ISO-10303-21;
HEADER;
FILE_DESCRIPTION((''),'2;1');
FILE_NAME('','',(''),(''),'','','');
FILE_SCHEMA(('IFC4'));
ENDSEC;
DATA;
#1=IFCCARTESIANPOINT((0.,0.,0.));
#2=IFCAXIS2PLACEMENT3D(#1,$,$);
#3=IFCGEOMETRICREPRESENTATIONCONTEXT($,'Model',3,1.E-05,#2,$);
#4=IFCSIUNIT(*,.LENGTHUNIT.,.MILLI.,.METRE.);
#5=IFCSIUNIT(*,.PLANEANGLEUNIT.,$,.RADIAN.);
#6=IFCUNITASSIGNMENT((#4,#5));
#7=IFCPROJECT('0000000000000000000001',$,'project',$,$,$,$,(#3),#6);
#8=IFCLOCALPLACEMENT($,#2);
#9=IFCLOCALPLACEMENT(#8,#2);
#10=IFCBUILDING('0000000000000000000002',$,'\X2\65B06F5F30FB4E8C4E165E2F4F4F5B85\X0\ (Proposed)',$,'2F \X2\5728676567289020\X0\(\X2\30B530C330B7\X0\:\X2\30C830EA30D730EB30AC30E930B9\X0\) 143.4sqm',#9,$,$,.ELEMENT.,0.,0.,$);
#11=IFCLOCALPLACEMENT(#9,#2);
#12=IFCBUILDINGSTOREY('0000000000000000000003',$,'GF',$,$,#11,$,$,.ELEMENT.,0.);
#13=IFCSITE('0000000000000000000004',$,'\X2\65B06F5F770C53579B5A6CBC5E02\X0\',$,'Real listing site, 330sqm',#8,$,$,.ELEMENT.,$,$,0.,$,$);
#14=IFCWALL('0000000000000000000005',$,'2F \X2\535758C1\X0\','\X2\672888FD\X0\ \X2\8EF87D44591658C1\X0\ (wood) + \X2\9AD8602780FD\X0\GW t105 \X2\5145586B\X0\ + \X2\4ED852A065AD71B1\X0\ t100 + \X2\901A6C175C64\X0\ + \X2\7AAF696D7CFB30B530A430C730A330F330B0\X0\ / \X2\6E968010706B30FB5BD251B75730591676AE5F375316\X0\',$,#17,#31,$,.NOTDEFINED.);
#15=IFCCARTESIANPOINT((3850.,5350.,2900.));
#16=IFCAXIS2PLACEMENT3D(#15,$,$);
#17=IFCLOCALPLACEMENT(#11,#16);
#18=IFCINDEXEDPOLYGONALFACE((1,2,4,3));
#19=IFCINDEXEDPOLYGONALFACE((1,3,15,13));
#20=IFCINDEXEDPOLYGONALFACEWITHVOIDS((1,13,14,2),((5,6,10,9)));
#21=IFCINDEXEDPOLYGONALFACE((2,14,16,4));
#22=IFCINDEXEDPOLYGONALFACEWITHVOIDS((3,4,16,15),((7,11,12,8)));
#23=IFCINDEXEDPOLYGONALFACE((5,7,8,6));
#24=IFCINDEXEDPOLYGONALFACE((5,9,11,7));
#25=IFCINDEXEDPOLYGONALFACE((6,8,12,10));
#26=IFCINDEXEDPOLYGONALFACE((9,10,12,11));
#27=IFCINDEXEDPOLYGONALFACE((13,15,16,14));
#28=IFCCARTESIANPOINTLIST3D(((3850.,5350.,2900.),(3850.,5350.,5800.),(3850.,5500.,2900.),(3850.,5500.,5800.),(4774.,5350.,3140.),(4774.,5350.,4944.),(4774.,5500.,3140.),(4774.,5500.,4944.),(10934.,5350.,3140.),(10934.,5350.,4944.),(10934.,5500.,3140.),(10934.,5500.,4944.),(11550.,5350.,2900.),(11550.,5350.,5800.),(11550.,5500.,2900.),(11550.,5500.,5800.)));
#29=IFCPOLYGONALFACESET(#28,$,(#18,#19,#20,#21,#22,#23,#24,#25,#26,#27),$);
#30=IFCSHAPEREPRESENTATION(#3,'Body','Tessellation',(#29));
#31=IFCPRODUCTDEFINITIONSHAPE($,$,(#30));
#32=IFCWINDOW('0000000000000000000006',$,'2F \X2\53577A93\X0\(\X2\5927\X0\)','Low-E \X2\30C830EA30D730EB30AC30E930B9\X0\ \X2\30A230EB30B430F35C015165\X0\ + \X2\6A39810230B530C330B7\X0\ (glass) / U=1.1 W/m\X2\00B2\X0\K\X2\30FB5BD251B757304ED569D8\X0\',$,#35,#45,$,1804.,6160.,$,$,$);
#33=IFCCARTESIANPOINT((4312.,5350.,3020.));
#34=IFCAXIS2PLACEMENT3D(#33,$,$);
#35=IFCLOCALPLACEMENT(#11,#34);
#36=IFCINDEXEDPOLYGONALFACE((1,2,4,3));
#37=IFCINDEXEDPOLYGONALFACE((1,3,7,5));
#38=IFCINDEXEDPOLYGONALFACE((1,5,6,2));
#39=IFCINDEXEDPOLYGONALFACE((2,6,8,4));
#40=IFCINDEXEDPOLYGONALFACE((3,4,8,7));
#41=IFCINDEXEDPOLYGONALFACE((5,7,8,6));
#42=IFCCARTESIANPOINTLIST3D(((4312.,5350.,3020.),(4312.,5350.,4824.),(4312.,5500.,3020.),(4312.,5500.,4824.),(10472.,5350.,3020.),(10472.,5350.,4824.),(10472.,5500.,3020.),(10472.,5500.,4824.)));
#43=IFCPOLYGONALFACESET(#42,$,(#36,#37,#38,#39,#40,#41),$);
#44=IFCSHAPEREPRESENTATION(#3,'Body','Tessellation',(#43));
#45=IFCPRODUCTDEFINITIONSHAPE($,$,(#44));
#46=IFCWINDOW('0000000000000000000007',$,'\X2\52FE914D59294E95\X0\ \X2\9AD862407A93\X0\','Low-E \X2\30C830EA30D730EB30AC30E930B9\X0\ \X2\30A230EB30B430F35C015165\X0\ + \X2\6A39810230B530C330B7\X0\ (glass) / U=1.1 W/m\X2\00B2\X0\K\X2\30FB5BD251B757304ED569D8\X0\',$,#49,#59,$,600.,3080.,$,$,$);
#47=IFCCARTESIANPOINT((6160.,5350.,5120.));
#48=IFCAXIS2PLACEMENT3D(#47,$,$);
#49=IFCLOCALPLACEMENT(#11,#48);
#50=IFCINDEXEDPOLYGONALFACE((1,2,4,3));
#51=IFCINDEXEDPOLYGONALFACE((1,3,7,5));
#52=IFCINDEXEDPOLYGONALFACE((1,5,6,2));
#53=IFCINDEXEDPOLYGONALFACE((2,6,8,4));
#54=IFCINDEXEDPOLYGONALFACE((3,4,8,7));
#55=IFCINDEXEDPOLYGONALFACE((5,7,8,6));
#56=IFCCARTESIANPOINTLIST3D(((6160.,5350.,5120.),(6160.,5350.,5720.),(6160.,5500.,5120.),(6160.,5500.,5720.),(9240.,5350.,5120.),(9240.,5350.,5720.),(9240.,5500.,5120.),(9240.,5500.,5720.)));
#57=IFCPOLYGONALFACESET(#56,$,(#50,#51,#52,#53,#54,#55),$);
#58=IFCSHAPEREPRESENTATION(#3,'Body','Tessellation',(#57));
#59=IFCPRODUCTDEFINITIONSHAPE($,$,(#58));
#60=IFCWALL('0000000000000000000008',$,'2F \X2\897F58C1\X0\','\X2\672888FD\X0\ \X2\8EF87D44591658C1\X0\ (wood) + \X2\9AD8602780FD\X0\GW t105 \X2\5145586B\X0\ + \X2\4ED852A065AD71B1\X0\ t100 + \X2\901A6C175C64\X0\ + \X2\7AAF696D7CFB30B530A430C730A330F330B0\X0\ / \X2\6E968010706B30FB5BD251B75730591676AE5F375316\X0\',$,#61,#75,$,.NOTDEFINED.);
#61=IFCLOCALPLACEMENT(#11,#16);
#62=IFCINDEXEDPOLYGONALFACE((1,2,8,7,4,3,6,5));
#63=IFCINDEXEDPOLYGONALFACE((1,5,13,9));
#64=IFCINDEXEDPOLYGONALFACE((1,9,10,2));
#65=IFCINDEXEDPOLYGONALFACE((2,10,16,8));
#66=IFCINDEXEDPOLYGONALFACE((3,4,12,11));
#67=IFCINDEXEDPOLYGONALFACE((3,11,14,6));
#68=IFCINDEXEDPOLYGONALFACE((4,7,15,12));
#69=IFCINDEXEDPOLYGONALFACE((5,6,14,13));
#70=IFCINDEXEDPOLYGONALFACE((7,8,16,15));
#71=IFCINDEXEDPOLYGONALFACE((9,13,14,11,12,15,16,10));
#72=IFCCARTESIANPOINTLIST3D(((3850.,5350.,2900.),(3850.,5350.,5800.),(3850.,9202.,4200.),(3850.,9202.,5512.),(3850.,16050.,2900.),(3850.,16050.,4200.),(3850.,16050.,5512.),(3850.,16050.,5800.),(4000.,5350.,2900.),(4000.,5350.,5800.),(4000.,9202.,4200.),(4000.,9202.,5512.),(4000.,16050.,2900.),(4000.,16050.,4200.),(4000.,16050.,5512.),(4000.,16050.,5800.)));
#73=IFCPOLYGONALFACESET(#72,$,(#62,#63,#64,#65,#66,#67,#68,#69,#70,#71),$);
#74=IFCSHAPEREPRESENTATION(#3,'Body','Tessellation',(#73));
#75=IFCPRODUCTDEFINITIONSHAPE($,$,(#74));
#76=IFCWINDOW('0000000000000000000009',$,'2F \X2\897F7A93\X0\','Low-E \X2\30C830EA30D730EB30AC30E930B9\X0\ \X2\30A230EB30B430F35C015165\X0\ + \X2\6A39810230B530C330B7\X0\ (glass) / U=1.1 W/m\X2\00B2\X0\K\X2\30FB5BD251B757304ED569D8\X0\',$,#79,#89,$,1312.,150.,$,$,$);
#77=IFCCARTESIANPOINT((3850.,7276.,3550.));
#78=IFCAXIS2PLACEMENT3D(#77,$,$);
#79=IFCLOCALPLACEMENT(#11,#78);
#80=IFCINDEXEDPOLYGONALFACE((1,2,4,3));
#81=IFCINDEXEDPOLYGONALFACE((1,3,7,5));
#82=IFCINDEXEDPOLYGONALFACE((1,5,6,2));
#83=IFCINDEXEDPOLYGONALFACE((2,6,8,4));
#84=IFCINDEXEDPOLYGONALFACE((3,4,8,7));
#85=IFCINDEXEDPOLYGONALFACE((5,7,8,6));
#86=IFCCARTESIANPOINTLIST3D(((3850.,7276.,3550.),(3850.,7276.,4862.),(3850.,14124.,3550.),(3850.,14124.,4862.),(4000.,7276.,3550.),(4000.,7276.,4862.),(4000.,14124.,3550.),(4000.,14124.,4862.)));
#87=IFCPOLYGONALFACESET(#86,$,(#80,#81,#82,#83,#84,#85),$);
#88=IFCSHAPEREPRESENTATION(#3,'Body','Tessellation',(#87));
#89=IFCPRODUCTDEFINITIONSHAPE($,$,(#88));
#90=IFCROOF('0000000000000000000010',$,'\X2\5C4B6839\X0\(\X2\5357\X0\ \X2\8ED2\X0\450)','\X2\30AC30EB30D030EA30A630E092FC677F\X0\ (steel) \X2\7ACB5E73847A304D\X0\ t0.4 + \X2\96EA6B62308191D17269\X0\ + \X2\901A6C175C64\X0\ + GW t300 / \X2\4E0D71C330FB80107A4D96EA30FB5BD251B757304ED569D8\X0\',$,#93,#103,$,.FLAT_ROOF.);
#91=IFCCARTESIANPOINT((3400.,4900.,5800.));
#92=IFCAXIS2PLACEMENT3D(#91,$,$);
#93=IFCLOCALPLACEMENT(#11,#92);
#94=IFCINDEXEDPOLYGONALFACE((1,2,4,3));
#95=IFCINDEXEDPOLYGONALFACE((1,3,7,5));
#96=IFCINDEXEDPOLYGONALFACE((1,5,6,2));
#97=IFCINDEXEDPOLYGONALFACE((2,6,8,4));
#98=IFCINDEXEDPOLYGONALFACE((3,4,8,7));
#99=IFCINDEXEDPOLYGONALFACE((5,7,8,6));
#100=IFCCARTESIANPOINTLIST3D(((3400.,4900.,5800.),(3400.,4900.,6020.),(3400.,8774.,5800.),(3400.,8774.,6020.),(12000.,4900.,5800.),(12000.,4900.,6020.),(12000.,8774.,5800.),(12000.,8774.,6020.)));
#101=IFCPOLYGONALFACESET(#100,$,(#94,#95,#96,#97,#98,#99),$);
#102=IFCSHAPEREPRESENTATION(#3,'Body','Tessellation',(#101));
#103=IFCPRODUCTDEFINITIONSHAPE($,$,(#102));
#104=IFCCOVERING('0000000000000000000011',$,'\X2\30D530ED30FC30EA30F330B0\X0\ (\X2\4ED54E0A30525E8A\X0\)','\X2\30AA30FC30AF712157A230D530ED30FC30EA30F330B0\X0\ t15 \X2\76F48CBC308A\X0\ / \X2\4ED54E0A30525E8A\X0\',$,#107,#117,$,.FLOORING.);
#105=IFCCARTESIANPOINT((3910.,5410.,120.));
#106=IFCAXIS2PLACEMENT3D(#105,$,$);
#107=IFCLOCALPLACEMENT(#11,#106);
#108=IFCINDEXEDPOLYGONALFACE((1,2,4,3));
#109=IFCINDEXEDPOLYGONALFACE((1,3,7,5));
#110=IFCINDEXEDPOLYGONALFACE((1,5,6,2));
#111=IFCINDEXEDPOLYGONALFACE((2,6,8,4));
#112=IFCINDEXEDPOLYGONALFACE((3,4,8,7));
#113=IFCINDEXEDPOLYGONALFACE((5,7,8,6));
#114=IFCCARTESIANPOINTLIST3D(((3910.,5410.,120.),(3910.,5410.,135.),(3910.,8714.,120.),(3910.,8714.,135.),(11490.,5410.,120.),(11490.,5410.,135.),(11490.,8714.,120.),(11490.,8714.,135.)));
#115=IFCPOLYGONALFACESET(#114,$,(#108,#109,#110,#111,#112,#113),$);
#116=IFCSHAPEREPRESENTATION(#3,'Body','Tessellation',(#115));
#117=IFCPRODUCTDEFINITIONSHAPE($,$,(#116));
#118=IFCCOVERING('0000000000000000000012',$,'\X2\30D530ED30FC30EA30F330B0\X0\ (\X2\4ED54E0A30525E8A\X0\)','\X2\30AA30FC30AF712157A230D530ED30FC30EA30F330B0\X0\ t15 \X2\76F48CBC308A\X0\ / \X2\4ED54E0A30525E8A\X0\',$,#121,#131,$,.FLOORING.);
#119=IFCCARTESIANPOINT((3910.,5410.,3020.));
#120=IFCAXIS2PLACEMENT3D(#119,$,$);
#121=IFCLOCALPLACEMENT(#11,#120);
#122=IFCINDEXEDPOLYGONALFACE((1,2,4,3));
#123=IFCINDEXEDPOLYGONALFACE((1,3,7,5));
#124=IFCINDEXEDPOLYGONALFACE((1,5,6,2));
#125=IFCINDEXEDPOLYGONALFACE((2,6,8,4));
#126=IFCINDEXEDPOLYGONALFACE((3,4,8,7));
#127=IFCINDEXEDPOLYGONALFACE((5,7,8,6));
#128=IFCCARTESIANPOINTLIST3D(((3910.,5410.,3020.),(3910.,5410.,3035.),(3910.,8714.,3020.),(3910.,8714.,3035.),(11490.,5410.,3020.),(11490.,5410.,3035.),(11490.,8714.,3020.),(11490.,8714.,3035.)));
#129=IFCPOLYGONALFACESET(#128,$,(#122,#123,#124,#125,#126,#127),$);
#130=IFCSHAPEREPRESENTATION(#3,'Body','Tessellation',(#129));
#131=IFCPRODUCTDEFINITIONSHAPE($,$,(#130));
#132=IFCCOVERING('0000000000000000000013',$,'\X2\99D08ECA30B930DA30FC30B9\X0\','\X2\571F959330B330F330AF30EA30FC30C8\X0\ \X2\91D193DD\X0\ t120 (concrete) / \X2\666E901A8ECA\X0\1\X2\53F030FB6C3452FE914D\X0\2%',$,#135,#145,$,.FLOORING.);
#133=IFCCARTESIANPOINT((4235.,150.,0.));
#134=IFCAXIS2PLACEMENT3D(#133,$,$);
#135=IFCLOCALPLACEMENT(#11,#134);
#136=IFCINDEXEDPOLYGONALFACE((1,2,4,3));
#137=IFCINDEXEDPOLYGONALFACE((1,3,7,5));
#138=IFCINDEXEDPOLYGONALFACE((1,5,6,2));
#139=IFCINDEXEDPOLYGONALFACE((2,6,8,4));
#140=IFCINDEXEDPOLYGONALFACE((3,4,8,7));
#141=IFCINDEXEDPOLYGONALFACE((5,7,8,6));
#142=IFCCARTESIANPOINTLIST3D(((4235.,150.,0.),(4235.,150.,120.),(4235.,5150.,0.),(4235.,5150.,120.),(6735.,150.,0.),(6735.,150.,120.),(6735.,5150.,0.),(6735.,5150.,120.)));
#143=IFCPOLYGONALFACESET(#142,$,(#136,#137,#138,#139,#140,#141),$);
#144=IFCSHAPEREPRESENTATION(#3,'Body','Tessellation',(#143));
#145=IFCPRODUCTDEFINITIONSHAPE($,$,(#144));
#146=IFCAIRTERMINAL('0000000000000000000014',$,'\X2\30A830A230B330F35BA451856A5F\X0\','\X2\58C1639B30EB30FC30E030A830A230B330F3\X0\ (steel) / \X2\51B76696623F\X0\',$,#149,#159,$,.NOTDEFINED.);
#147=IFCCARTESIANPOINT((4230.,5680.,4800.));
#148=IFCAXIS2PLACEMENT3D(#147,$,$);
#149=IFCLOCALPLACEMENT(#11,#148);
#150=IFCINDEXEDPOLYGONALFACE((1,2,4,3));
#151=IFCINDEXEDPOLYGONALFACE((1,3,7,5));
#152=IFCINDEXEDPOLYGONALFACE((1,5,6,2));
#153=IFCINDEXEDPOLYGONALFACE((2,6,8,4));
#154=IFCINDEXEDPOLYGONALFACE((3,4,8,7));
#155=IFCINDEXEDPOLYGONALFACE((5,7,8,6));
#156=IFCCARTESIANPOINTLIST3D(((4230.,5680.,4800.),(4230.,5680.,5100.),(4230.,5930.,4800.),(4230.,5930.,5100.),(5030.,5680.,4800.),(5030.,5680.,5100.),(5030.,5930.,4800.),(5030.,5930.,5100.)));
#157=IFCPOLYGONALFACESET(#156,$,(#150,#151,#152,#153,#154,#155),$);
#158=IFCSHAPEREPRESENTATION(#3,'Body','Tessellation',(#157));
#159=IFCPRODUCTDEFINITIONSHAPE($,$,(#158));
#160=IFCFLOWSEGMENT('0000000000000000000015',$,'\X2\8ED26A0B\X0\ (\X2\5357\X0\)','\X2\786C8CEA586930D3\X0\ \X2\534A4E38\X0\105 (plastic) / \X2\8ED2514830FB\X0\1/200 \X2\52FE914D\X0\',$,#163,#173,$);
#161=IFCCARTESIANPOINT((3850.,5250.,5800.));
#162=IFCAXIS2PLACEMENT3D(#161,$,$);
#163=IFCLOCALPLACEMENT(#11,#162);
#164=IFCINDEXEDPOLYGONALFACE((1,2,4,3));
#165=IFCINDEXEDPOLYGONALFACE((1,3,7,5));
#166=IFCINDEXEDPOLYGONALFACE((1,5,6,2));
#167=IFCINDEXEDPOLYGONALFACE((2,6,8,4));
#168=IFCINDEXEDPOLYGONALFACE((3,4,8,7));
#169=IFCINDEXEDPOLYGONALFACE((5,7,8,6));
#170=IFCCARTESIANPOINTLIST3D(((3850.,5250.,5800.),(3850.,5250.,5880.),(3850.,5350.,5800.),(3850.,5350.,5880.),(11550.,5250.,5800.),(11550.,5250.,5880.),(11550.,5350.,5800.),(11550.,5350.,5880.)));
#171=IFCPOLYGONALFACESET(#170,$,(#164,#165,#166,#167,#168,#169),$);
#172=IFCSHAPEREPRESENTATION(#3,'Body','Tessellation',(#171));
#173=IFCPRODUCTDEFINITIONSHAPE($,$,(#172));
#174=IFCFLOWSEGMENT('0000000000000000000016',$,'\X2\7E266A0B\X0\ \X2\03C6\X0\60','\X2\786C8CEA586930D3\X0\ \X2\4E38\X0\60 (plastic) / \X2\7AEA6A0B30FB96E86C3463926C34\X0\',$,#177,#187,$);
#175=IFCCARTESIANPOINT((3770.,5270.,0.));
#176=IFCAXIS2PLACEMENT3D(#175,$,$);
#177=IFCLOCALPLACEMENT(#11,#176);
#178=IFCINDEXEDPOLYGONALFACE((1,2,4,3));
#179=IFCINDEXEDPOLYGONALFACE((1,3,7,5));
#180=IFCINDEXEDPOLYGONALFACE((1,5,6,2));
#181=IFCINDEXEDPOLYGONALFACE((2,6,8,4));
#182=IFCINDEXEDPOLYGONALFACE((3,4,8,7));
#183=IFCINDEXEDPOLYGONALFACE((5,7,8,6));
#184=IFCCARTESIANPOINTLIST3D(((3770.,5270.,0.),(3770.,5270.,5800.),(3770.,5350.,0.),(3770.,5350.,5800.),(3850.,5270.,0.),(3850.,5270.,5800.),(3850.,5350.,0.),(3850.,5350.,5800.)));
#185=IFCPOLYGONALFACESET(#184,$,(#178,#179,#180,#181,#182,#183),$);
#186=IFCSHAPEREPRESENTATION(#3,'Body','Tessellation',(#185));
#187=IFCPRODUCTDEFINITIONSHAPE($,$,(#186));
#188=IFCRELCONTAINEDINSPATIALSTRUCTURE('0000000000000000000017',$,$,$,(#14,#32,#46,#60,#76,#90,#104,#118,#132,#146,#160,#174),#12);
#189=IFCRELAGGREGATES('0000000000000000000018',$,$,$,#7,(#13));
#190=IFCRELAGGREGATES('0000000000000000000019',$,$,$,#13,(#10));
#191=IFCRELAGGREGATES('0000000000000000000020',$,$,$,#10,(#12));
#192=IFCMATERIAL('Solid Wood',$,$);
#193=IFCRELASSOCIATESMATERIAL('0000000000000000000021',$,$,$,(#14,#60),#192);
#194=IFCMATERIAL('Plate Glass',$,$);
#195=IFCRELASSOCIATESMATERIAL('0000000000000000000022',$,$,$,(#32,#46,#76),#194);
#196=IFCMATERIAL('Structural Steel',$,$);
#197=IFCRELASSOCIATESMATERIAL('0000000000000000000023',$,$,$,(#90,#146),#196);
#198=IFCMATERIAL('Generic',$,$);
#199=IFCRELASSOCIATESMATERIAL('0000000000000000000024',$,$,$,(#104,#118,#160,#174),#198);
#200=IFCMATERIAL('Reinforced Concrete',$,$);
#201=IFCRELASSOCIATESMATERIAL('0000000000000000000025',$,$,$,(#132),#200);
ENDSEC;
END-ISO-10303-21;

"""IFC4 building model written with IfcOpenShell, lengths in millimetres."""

from ifc_helpers import new_model, si_unit, frame, frame_2d, origin, place, context, project, spatial, rectangle, extrude, material, element, fill, save


model = new_model("IFC4")

# Units and contexts
model_context = context("Model", 3, precision=1e-05, world=origin())
ifc_project = project(units=[si_unit("LENGTHUNIT", "METRE", prefix="MILLI"), si_unit("PLANEANGLEUNIT", "RADIAN")], contexts=[model_context])

# Site, building, storey
site_placement = place(None, origin())
site = spatial("IfcSite", under=ifc_project, at=site_placement, Name="新潟県南魚沼市", ObjectType="Real listing site, 330sqm", CompositionType="ELEMENT", RefElevation=0.0)
building_placement = place(site_placement, origin())
building = spatial("IfcBuilding", under=site, at=building_placement, Name="新潟・二世帯住宅 (Proposed)", ObjectType="2F 在来木造(サッシ:トリプルガラス) 143.4sqm", CompositionType="ELEMENT", ElevationOfRefHeight=0.0, ElevationOfTerrain=0.0)
storey_placement = place(building_placement, origin())
storey = spatial("IfcBuildingStorey", under=building, at=storey_placement, Name="GF", CompositionType="ELEMENT", Elevation=0.0)

# Shared definitions
ifc_material_1 = material(Name="Solid Wood")

# Shared definitions
ifc_material_2 = material(Name="Reinforced Concrete")

# Shared definitions
ifc_material_3 = material(Name="Plate Glass")

# Wall, openings, windows
wall_1_placement = place(storey_placement, frame((3850.0, 5350.0, 2900.0)))
wall_1 = element("IfcWall", 1, at=wall_1_placement, inside=storey, material=ifc_material_1, Name="2F 南壁", Description="木製 軸組外壁 (wood) + 高性能GW t105 充填 + 付加断熱 t100 + 通気層 + 窯業系サイディング / 準耐火・寒冷地外皮強化", PredefinedType="NOTDEFINED", context=model_context, shape_type="SweptSolid", body=[
    extrude(rectangle(XDim=7700.0, YDim=150.0, at=frame_2d((3850.0, 75.0))), frame((3850.0, 5350.0, 2900.0)), (0.0, 0.0, 1.0), 2900.0),
])
opening_1_placement = place(storey_placement, frame((4312.0, 5350.0, 3020.0)))
opening_1 = element("IfcOpeningElement", 2, at=opening_1_placement, cuts=wall_1, PredefinedType="NOTDEFINED", context=model_context, shape_type="SweptSolid", body=[
    extrude(rectangle(XDim=6160.0, YDim=150.0, at=frame_2d((3080.0, 75.0))), frame((4312.0, 5350.0, 3020.0)), (0.0, 0.0, 1.0), 1804.0),
])
opening_2_placement = place(storey_placement, frame((6160.0, 5350.0, 5120.0)))
opening_2 = element("IfcOpeningElement", 3, at=opening_2_placement, cuts=wall_1, PredefinedType="NOTDEFINED", context=model_context, shape_type="SweptSolid", body=[
    extrude(rectangle(XDim=3080.0, YDim=150.0, at=frame_2d((1540.0, 75.0))), frame((6160.0, 5350.0, 5120.0)), (0.0, 0.0, 1.0), 600.0),
])
window_1_placement = place(storey_placement, frame((4312.0, 5350.0, 3020.0)))
window_1 = element("IfcWindow", 4, at=window_1_placement, inside=storey, material=ifc_material_3, Name="2F 南窓(大)", Description="Low-E トリプルガラス アルゴン封入 + 樹脂サッシ (glass) / U=1.1 W/m²K・寒冷地仕様", OverallHeight=1804.0, OverallWidth=6160.0, context=model_context, shape_type="SweptSolid", body=[
    extrude(rectangle(XDim=6160.0, YDim=150.0, at=frame_2d((3080.0, 75.0))), frame((4312.0, 5350.0, 3020.0)), (0.0, 0.0, 1.0), 1804.0),
])
fill(opening_1, window_1)
window_2_placement = place(storey_placement, frame((6160.0, 5350.0, 5120.0)))
window_2 = element("IfcWindow", 5, at=window_2_placement, inside=storey, material=ifc_material_3, Name="勾配天井 高所窓", Description="Low-E トリプルガラス アルゴン封入 + 樹脂サッシ (glass) / U=1.1 W/m²K・寒冷地仕様", OverallHeight=600.0, OverallWidth=3080.0, context=model_context, shape_type="SweptSolid", body=[
    extrude(rectangle(XDim=3080.0, YDim=150.0, at=frame_2d((1540.0, 75.0))), frame((6160.0, 5350.0, 5120.0)), (0.0, 0.0, 1.0), 600.0),
])
fill(opening_2, window_2)

# Wall, opening, window
wall_2_placement = place(storey_placement, frame((3850.0, 5350.0, 2900.0)))
wall_2 = element("IfcWall", 6, at=wall_2_placement, inside=storey, material=ifc_material_1, Name="2F 西壁", Description="木製 軸組外壁 (wood) + 高性能GW t105 充填 + 付加断熱 t100 + 通気層 + 窯業系サイディング / 準耐火・寒冷地外皮強化", PredefinedType="NOTDEFINED", context=model_context, shape_type="SweptSolid", body=[
    extrude(rectangle(XDim=150.0, YDim=10700.0, at=frame_2d((75.0, 5350.0))), frame((3850.0, 5350.0, 2900.0)), (0.0, 0.0, 1.0), 2900.0),
])
opening_3_placement = place(storey_placement, frame((3850.0, 7276.0, 3550.0)))
opening_3 = element("IfcOpeningElement", 7, at=opening_3_placement, cuts=wall_2, PredefinedType="NOTDEFINED", context=model_context, shape_type="SweptSolid", body=[
    extrude(rectangle(XDim=150.0, YDim=6848.0, at=frame_2d((75.0, 3424.0))), frame((3850.0, 7276.0, 3550.0)), (0.0, 0.0, 1.0), 1312.0),
])
window_3_placement = place(storey_placement, frame((3850.0, 7276.0, 3550.0)))
window_3 = element("IfcWindow", 8, at=window_3_placement, inside=storey, material=ifc_material_3, Name="2F 西窓", Description="Low-E トリプルガラス アルゴン封入 + 樹脂サッシ (glass) / U=1.1 W/m²K・寒冷地仕様", OverallHeight=1312.0, OverallWidth=150.0, context=model_context, shape_type="SweptSolid", body=[
    extrude(rectangle(XDim=150.0, YDim=6848.0, at=frame_2d((75.0, 3424.0))), frame((3850.0, 7276.0, 3550.0)), (0.0, 0.0, 1.0), 1312.0),
])
fill(opening_3, window_3)

# Roof
ifc_material_4 = material(Name="Structural Steel")
for number, where, name in (
    (9, (3400.0, 4900.0, 5800.0), "屋根(南 軒450)"),
):
    element("IfcRoof", number, at=place(storey_placement, frame(where)), inside=storey, material=ifc_material_4, Name=name, Description="ガルバリウム鋼板 (steel) 立平葺き t0.4 + 雪止め金物 + 通気層 + GW t300 / 不燃・耐積雪・寒冷地仕様", PredefinedType="FLAT_ROOF", context=model_context, shape_type="SweptSolid", body=[
        extrude(rectangle(XDim=8600.0, YDim=3874.0, at=frame_2d((4300.0, 1937.0))), frame((3400.0, 4900.0, 5800.0)), (0.0, 0.0, 1.0), 220.0),
    ])

# Coverings
ifc_material_5 = material(Name="Generic")
covering_1_placement = place(storey_placement, frame((3910.0, 5410.0, 120.0)))
element("IfcCovering", 10, at=covering_1_placement, inside=storey, material=ifc_material_5, Name="フローリング (仕上げ床)", Description="オーク無垢フローリング t15 直貼り / 仕上げ床", PredefinedType="FLOORING", context=model_context, shape_type="SweptSolid", body=[
    extrude(rectangle(XDim=7580.0, YDim=3304.0, at=frame_2d((3790.0, 1652.0))), frame((3910.0, 5410.0, 120.0)), (0.0, 0.0, 1.0), 15.0),
])
covering_2_placement = place(storey_placement, frame((3910.0, 5410.0, 3020.0)))
element("IfcCovering", 11, at=covering_2_placement, inside=storey, material=ifc_material_5, Name="フローリング (仕上げ床)", Description="オーク無垢フローリング t15 直貼り / 仕上げ床", PredefinedType="FLOORING", context=model_context, shape_type="SweptSolid", body=[
    extrude(rectangle(XDim=7580.0, YDim=3304.0, at=frame_2d((3790.0, 1652.0))), frame((3910.0, 5410.0, 3020.0)), (0.0, 0.0, 1.0), 15.0),
])
covering_3_placement = place(storey_placement, frame((4235.0, 150.0, 0.0)))
element("IfcCovering", 12, at=covering_3_placement, inside=storey, material=ifc_material_2, Name="駐車スペース", Description="土間コンクリート 金鏝 t120 (concrete) / 普通車1台・水勾配2%", PredefinedType="FLOORING", context=model_context, shape_type="SweptSolid", body=[
    extrude(rectangle(XDim=2500.0, YDim=5000.0, at=frame_2d((1250.0, 2500.0))), frame((4235.0, 150.0, 0.0)), (0.0, 0.0, 1.0), 120.0),
])

# Air terminal
air_terminal_placement = place(storey_placement, frame((4230.0, 5680.0, 4800.0)))
element("IfcAirTerminal", 13, at=air_terminal_placement, inside=storey, material=ifc_material_4, Name="エアコン室内機", Description="壁掛ルームエアコン (steel) / 冷暖房", PredefinedType="NOTDEFINED", context=model_context, shape_type="SweptSolid", body=[
    extrude(rectangle(XDim=800.0, YDim=250.0, at=frame_2d((400.0, 125.0))), frame((4230.0, 5680.0, 4800.0)), (0.0, 0.0, 1.0), 300.0),
])

# Flow segments
flow_segment_1_placement = place(storey_placement, frame((3850.0, 5250.0, 5800.0)))
element("IfcFlowSegment", 14, at=flow_segment_1_placement, inside=storey, material=ifc_material_5, Name="軒樋 (南)", Description="硬質塩ビ 半丸105 (plastic) / 軒先・1/200 勾配", context=model_context, shape_type="SweptSolid", body=[
    extrude(rectangle(XDim=7700.0, YDim=100.0, at=frame_2d((3850.0, 50.0))), frame((3850.0, 5250.0, 5800.0)), (0.0, 0.0, 1.0), 80.0),
])
flow_segment_2_placement = place(storey_placement, frame((3770.0, 5270.0, 0.0)))
element("IfcFlowSegment", 15, at=flow_segment_2_placement, inside=storey, material=ifc_material_5, Name="縦樋 φ60", Description="硬質塩ビ 丸60 (plastic) / 竪樋・雨水排水", context=model_context, shape_type="SweptSolid", body=[
    extrude(rectangle(XDim=80.0, YDim=80.0, at=frame_2d((40.0, 40.0))), frame((3770.0, 5270.0, 0.0)), (0.0, 0.0, 1.0), 5800.0),
])

save(model, "model.ifc")
